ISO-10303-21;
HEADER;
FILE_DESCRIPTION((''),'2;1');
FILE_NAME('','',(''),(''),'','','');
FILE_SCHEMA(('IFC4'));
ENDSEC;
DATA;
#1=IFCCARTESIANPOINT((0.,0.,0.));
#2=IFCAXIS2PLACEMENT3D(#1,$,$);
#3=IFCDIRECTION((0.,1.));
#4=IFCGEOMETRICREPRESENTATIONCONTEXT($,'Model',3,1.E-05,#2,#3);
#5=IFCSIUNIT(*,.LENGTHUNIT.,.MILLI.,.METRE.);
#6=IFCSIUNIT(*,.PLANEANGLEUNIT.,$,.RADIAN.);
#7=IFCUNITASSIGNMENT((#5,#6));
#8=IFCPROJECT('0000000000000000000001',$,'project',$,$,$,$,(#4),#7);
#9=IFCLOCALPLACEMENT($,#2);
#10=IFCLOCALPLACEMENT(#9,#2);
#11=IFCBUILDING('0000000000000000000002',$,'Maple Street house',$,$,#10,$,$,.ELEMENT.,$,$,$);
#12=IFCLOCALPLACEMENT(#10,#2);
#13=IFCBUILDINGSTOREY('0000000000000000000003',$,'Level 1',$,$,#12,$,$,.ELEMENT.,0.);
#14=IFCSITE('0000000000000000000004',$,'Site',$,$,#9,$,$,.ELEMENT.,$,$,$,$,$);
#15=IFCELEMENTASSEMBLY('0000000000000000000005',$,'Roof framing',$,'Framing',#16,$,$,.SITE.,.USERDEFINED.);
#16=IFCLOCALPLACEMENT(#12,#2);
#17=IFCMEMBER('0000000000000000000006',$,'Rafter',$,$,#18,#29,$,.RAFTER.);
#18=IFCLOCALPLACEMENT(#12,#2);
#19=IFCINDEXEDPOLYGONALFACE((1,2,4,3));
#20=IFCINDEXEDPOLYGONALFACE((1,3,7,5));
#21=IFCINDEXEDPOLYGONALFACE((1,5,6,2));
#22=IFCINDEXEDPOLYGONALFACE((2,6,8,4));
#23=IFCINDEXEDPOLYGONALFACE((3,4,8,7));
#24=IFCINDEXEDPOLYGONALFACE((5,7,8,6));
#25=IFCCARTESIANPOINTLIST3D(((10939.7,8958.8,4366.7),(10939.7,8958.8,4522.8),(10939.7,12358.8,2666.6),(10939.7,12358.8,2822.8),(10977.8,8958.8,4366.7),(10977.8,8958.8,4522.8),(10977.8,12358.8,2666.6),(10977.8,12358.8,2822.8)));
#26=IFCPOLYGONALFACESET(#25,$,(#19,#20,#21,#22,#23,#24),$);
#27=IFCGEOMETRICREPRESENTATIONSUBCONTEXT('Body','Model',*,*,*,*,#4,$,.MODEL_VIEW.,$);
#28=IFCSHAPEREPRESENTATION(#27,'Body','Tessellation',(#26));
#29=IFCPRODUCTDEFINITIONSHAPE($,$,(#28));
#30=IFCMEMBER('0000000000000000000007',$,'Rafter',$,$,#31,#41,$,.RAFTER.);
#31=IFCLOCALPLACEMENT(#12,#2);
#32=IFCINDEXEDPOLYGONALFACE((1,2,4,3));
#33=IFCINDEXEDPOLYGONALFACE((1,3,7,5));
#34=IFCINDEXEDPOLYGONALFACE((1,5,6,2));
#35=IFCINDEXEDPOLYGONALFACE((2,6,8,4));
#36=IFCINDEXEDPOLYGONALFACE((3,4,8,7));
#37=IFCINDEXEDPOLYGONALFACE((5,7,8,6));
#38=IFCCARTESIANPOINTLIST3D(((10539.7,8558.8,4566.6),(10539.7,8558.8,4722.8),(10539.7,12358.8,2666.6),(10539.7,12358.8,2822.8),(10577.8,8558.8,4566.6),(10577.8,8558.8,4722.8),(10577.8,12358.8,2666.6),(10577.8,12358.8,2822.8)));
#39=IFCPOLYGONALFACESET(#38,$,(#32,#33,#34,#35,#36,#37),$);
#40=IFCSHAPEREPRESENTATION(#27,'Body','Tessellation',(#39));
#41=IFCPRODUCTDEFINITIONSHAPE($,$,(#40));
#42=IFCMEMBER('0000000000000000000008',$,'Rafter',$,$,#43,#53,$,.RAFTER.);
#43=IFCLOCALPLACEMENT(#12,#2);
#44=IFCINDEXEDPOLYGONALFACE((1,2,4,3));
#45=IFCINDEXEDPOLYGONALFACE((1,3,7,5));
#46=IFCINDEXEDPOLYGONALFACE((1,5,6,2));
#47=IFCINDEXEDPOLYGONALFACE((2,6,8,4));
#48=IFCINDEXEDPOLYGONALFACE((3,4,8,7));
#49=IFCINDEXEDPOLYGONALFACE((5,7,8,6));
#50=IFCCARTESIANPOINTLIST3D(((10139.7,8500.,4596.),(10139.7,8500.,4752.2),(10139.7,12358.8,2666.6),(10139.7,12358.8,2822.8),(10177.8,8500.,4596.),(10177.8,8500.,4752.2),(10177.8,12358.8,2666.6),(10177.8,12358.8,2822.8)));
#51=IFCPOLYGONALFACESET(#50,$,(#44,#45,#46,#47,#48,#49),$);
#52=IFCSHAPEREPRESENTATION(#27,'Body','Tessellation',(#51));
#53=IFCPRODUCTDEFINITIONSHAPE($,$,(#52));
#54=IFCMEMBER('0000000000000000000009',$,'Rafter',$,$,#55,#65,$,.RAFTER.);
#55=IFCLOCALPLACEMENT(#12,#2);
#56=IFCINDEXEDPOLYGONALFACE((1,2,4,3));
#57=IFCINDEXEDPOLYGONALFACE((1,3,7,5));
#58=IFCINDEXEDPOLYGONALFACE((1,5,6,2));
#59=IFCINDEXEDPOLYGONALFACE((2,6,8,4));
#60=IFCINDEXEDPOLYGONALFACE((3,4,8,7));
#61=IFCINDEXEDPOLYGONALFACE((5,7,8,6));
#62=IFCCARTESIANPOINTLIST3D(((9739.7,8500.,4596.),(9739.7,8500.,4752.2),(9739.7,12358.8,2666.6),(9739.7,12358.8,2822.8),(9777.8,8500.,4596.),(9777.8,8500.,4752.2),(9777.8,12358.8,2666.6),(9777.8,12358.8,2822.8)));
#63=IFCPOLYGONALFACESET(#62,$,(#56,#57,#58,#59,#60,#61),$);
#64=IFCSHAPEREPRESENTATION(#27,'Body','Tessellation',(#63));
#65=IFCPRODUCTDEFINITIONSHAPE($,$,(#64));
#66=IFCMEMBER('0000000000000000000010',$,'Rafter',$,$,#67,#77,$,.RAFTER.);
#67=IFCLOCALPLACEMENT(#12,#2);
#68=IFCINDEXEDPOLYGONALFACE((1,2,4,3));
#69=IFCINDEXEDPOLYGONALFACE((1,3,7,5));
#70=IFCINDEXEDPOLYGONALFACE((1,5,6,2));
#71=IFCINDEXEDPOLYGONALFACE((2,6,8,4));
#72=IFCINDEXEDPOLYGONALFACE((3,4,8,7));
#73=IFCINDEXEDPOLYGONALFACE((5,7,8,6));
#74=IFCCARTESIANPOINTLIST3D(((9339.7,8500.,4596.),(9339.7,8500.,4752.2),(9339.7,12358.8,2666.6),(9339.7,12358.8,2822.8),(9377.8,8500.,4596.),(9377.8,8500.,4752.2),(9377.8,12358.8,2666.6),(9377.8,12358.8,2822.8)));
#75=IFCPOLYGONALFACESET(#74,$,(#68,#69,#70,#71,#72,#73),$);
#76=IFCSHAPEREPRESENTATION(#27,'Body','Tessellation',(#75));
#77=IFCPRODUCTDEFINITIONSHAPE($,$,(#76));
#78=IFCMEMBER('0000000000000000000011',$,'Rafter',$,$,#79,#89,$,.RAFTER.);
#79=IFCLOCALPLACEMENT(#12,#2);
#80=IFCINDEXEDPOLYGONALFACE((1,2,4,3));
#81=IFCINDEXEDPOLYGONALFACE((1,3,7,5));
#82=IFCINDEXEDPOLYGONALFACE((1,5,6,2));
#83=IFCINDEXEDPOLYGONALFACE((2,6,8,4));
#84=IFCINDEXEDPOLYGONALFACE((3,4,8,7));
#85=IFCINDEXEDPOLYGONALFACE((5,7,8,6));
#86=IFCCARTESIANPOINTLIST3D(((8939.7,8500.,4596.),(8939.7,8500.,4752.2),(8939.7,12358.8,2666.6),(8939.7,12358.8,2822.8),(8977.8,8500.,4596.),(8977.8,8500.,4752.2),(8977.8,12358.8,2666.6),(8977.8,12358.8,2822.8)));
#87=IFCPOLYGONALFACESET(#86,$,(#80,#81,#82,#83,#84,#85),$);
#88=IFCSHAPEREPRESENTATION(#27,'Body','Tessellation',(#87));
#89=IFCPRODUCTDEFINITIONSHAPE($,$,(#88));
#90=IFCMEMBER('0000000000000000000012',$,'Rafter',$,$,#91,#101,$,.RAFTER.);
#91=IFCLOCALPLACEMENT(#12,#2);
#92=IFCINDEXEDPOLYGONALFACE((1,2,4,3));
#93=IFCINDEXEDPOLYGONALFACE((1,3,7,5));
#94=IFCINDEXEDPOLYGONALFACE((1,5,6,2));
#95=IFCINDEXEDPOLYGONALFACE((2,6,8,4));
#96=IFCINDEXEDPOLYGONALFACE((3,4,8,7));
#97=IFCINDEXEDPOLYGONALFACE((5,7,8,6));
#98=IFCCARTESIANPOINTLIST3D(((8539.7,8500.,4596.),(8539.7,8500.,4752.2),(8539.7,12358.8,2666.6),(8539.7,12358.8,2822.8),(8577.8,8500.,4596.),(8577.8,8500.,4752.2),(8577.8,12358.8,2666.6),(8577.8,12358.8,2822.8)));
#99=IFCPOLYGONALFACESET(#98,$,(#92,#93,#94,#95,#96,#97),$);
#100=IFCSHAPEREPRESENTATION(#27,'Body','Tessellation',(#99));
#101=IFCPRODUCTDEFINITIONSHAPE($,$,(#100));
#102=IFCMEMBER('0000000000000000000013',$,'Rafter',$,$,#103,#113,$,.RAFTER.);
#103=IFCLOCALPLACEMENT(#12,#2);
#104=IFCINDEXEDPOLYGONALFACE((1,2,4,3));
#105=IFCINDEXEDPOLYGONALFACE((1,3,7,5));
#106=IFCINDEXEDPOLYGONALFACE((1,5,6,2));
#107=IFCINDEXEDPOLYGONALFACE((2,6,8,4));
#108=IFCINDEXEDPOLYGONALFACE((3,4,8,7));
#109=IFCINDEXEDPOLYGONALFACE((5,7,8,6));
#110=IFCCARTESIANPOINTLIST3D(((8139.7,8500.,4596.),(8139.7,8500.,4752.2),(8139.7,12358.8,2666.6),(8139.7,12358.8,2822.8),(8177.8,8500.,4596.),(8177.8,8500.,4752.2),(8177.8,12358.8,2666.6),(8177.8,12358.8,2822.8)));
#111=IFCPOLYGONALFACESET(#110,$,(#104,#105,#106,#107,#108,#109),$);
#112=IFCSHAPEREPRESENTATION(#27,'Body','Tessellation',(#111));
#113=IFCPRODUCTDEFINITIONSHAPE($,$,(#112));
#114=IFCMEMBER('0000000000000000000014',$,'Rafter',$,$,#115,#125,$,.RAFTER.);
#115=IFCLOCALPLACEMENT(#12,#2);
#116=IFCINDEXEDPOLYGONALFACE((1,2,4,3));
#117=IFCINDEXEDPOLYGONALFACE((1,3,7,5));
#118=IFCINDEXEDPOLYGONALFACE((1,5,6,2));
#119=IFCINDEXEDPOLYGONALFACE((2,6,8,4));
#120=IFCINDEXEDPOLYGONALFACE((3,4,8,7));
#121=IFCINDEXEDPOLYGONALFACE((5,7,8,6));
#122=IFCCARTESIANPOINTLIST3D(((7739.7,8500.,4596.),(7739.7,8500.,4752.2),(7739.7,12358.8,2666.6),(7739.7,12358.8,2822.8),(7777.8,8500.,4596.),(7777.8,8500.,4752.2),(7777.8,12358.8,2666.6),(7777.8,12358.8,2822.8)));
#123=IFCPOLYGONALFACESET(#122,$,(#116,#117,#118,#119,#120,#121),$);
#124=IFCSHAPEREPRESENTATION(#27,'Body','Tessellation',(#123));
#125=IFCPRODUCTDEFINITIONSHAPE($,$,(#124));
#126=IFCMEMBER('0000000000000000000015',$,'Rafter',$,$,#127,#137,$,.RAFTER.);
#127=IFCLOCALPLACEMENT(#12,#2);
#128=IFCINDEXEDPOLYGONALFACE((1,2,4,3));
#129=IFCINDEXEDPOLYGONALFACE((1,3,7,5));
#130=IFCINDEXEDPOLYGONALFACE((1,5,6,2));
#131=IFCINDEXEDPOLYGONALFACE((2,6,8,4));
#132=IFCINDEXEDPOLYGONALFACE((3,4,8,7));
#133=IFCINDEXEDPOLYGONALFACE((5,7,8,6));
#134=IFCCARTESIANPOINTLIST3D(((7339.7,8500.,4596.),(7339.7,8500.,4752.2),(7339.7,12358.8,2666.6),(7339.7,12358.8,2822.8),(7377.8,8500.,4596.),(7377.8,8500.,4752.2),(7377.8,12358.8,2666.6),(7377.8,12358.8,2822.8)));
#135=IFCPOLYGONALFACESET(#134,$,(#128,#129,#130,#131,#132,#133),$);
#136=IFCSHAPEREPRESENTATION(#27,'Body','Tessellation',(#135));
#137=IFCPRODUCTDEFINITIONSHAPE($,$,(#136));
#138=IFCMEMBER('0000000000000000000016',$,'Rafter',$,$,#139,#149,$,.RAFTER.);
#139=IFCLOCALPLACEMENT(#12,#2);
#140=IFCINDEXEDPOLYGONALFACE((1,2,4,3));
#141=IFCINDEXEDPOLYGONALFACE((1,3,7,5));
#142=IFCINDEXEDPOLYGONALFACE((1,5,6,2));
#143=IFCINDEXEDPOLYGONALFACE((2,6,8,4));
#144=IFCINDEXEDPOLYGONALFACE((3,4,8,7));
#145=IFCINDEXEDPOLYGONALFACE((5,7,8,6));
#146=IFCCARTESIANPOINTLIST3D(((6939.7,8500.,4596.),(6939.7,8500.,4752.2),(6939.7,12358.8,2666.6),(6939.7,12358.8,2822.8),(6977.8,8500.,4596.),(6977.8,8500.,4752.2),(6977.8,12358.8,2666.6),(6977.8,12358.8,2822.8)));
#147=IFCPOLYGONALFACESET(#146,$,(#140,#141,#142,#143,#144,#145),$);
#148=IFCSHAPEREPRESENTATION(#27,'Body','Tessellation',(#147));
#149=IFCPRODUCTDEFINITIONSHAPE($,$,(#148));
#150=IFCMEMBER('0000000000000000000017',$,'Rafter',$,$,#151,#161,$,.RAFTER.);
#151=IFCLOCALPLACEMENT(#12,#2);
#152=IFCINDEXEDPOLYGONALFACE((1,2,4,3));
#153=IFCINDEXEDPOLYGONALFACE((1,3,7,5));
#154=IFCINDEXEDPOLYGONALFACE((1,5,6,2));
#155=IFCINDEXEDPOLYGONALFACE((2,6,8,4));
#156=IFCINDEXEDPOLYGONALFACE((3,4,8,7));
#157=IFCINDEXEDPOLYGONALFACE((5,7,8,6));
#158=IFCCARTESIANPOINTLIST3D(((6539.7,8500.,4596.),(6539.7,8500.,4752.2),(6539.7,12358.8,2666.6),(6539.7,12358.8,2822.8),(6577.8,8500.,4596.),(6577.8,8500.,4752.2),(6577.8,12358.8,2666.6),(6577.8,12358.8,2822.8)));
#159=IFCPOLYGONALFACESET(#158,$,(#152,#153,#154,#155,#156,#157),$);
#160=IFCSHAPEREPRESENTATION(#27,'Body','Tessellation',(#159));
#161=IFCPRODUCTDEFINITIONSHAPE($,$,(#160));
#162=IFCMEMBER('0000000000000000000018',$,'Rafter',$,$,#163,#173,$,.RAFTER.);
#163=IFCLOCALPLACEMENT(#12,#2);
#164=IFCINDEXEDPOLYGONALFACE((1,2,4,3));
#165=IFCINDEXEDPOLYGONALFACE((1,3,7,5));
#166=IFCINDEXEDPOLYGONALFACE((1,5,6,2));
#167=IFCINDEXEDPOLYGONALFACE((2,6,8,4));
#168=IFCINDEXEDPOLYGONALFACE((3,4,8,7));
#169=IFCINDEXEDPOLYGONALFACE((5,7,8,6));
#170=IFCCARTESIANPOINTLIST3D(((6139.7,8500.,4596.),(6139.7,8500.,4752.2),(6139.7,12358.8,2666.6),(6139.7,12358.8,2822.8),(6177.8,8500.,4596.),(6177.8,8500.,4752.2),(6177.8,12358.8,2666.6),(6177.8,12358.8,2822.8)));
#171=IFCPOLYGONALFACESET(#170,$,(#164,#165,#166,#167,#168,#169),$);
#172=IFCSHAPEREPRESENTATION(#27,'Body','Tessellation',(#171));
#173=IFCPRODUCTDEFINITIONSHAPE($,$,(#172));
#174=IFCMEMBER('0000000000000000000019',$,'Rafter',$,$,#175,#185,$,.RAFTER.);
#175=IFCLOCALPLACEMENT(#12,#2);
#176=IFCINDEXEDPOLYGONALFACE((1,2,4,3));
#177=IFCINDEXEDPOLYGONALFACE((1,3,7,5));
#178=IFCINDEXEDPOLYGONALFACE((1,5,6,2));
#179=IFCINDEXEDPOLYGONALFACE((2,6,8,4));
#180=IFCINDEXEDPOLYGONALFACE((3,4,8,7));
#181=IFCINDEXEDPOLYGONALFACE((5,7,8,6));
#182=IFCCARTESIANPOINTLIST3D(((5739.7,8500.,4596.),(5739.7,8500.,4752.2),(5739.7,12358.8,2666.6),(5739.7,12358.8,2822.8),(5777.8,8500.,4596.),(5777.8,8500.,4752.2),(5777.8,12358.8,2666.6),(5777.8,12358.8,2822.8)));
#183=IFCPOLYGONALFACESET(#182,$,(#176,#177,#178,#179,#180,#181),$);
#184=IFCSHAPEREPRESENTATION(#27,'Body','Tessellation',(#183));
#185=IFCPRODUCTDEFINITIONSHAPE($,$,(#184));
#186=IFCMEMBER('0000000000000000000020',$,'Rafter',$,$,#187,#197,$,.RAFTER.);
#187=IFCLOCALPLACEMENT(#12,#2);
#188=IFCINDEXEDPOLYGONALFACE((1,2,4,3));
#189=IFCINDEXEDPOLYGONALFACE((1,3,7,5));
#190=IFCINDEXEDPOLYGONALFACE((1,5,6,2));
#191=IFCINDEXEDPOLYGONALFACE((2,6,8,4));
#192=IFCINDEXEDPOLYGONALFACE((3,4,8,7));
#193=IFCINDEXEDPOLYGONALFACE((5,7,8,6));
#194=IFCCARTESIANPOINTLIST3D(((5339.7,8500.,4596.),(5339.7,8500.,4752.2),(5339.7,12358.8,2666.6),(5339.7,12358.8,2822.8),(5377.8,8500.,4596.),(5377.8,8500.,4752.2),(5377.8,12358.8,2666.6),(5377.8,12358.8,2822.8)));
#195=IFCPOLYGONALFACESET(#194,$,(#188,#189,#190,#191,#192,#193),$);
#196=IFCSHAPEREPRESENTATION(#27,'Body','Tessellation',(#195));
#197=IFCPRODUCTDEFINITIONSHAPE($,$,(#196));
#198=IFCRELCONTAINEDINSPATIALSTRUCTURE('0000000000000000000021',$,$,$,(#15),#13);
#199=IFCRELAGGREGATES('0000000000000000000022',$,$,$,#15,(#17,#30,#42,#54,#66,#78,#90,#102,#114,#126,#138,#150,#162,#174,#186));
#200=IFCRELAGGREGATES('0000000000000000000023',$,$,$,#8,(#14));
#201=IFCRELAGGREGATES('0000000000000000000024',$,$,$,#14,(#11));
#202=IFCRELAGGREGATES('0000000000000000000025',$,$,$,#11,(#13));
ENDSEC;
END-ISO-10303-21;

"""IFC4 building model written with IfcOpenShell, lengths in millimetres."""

from ifc_helpers import new_model, si_unit, direction, frame, origin, origin_with_axes, place, context, subcontext, project, spatial, polyline, outline, extrude, element, aggregate, save


model = new_model("IFC4")

# Units and contexts
model_context = context("Model", 3, precision=1e-05, world=origin(), true_north=direction((0.0, 1.0)))
body_context = subcontext(model_context, "Body", "Model", "MODEL_VIEW")
ifc_project = project(units=[si_unit("LENGTHUNIT", "METRE", prefix="MILLI"), si_unit("PLANEANGLEUNIT", "RADIAN")], contexts=[model_context])

# Site, building, storey
site_placement = place(None, origin())
site = spatial("IfcSite", under=ifc_project, at=site_placement, Name="Site", CompositionType="ELEMENT")
building_placement = place(site_placement, origin())
building = spatial("IfcBuilding", under=site, at=building_placement, Name="Maple Street house", CompositionType="ELEMENT")
storey_placement = place(building_placement, origin())
storey = spatial("IfcBuildingStorey", under=building, at=storey_placement, Name="Level 1", CompositionType="ELEMENT", Elevation=0.0)

# Element assembly, members
assembly_placement = place(storey_placement, origin_with_axes())
assembly = element("IfcElementAssembly", 1, at=assembly_placement, inside=storey, Name="Roof framing", ObjectType="Framing", AssemblyPlace="SITE", PredefinedType="USERDEFINED")
member_1_placement = place(storey_placement, origin_with_axes())
member_1 = element("IfcMember", 2, at=member_1_placement, Name="Rafter", PredefinedType="RAFTER", context=body_context, shape_type="SweptSolid", body=[
    extrude(outline(polyline([(0.0, 0.0), (38.1, 0.0), (38.1, 156.2), (0.0, 156.2), (0.0, 0.0)])), frame((10939.7, 12358.8, 2666.7), z_axis=(0.0, -1.0, 0.0), x_axis=(1.0, 0.0, 0.0)), (0.0, 0.447214, 0.894427), 3801.3),
])
member_2_placement = place(storey_placement, origin_with_axes())
member_2 = element("IfcMember", 3, at=member_2_placement, Name="Rafter", PredefinedType="RAFTER", context=body_context, shape_type="SweptSolid", body=[
    extrude(outline(polyline([(0.0, 0.0), (38.1, 0.0), (38.1, 156.2), (0.0, 156.2), (0.0, 0.0)])), frame((10539.7, 12358.8, 2666.7), z_axis=(0.0, -1.0, 0.0), x_axis=(1.0, 0.0, 0.0)), (0.0, 0.447214, 0.894427), 4248.5),
])
member_3_placement = place(storey_placement, origin_with_axes())
member_3 = element("IfcMember", 4, at=member_3_placement, Name="Rafter", PredefinedType="RAFTER", context=body_context, shape_type="SweptSolid", body=[
    extrude(outline(polyline([(0.0, 0.0), (38.1, 0.0), (38.1, 156.2), (0.0, 156.2), (0.0, 0.0)])), frame((10139.7, 12358.8, 2666.7), z_axis=(0.0, -1.0, 0.0), x_axis=(1.0, 0.0, 0.0)), (0.0, 0.447214, 0.894427), 4314.2),
])
member_4_placement = place(storey_placement, origin_with_axes())
member_4 = element("IfcMember", 5, at=member_4_placement, Name="Rafter", PredefinedType="RAFTER", context=body_context, shape_type="SweptSolid", body=[
    extrude(outline(polyline([(0.0, 0.0), (38.1, 0.0), (38.1, 156.2), (0.0, 156.2), (0.0, 0.0)])), frame((9739.7, 12358.8, 2666.7), z_axis=(0.0, -1.0, 0.0), x_axis=(1.0, 0.0, 0.0)), (0.0, 0.447214, 0.894427), 4314.2),
])
member_5_placement = place(storey_placement, origin_with_axes())
member_5 = element("IfcMember", 6, at=member_5_placement, Name="Rafter", PredefinedType="RAFTER", context=body_context, shape_type="SweptSolid", body=[
    extrude(outline(polyline([(0.0, 0.0), (38.1, 0.0), (38.1, 156.2), (0.0, 156.2), (0.0, 0.0)])), frame((9339.7, 12358.8, 2666.7), z_axis=(0.0, -1.0, 0.0), x_axis=(1.0, 0.0, 0.0)), (0.0, 0.447214, 0.894427), 4314.2),
])
member_6_placement = place(storey_placement, origin_with_axes())
member_6 = element("IfcMember", 7, at=member_6_placement, Name="Rafter", PredefinedType="RAFTER", context=body_context, shape_type="SweptSolid", body=[
    extrude(outline(polyline([(0.0, 0.0), (38.1, 0.0), (38.1, 156.2), (0.0, 156.2), (0.0, 0.0)])), frame((8939.7, 12358.8, 2666.7), z_axis=(0.0, -1.0, 0.0), x_axis=(1.0, 0.0, 0.0)), (0.0, 0.447214, 0.894427), 4314.2),
])
member_7_placement = place(storey_placement, origin_with_axes())
member_7 = element("IfcMember", 8, at=member_7_placement, Name="Rafter", PredefinedType="RAFTER", context=body_context, shape_type="SweptSolid", body=[
    extrude(outline(polyline([(0.0, 0.0), (38.1, 0.0), (38.1, 156.2), (0.0, 156.2), (0.0, 0.0)])), frame((8539.7, 12358.8, 2666.7), z_axis=(0.0, -1.0, 0.0), x_axis=(1.0, 0.0, 0.0)), (0.0, 0.447214, 0.894427), 4314.2),
])
member_8_placement = place(storey_placement, origin_with_axes())
member_8 = element("IfcMember", 9, at=member_8_placement, Name="Rafter", PredefinedType="RAFTER", context=body_context, shape_type="SweptSolid", body=[
    extrude(outline(polyline([(0.0, 0.0), (38.1, 0.0), (38.1, 156.2), (0.0, 156.2), (0.0, 0.0)])), frame((8139.7, 12358.8, 2666.7), z_axis=(0.0, -1.0, 0.0), x_axis=(1.0, 0.0, 0.0)), (0.0, 0.447214, 0.894427), 4314.2),
])
member_9_placement = place(storey_placement, origin_with_axes())
member_9 = element("IfcMember", 10, at=member_9_placement, Name="Rafter", PredefinedType="RAFTER", context=body_context, shape_type="SweptSolid", body=[
    extrude(outline(polyline([(0.0, 0.0), (38.1, 0.0), (38.1, 156.2), (0.0, 156.2), (0.0, 0.0)])), frame((7739.7, 12358.8, 2666.7), z_axis=(0.0, -1.0, 0.0), x_axis=(1.0, 0.0, 0.0)), (0.0, 0.447214, 0.894427), 4314.2),
])
member_10_placement = place(storey_placement, origin_with_axes())
member_10 = element("IfcMember", 11, at=member_10_placement, Name="Rafter", PredefinedType="RAFTER", context=body_context, shape_type="SweptSolid", body=[
    extrude(outline(polyline([(0.0, 0.0), (38.1, 0.0), (38.1, 156.2), (0.0, 156.2), (0.0, 0.0)])), frame((7339.7, 12358.8, 2666.7), z_axis=(0.0, -1.0, 0.0), x_axis=(1.0, 0.0, 0.0)), (0.0, 0.447214, 0.894427), 4314.2),
])
member_11_placement = place(storey_placement, origin_with_axes())
member_11 = element("IfcMember", 12, at=member_11_placement, Name="Rafter", PredefinedType="RAFTER", context=body_context, shape_type="SweptSolid", body=[
    extrude(outline(polyline([(0.0, 0.0), (38.1, 0.0), (38.1, 156.2), (0.0, 156.2), (0.0, 0.0)])), frame((6939.7, 12358.8, 2666.7), z_axis=(0.0, -1.0, 0.0), x_axis=(1.0, 0.0, 0.0)), (0.0, 0.447214, 0.894427), 4314.2),
])
member_12_placement = place(storey_placement, origin_with_axes())
member_12 = element("IfcMember", 13, at=member_12_placement, Name="Rafter", PredefinedType="RAFTER", context=body_context, shape_type="SweptSolid", body=[
    extrude(outline(polyline([(0.0, 0.0), (38.1, 0.0), (38.1, 156.2), (0.0, 156.2), (0.0, 0.0)])), frame((6539.7, 12358.8, 2666.7), z_axis=(0.0, -1.0, 0.0), x_axis=(1.0, 0.0, 0.0)), (0.0, 0.447214, 0.894427), 4314.2),
])
member_13_placement = place(storey_placement, origin_with_axes())
member_13 = element("IfcMember", 14, at=member_13_placement, Name="Rafter", PredefinedType="RAFTER", context=body_context, shape_type="SweptSolid", body=[
    extrude(outline(polyline([(0.0, 0.0), (38.1, 0.0), (38.1, 156.2), (0.0, 156.2), (0.0, 0.0)])), frame((6139.7, 12358.8, 2666.7), z_axis=(0.0, -1.0, 0.0), x_axis=(1.0, 0.0, 0.0)), (0.0, 0.447214, 0.894427), 4314.2),
])
member_14_placement = place(storey_placement, origin_with_axes())
member_14 = element("IfcMember", 15, at=member_14_placement, Name="Rafter", PredefinedType="RAFTER", context=body_context, shape_type="SweptSolid", body=[
    extrude(outline(polyline([(0.0, 0.0), (38.1, 0.0), (38.1, 156.2), (0.0, 156.2), (0.0, 0.0)])), frame((5739.7, 12358.8, 2666.7), z_axis=(0.0, -1.0, 0.0), x_axis=(1.0, 0.0, 0.0)), (0.0, 0.447214, 0.894427), 4314.2),
])
member_15_placement = place(storey_placement, origin_with_axes())
member_15 = element("IfcMember", 16, at=member_15_placement, Name="Rafter", PredefinedType="RAFTER", context=body_context, shape_type="SweptSolid", body=[
    extrude(outline(polyline([(0.0, 0.0), (38.1, 0.0), (38.1, 156.2), (0.0, 156.2), (0.0, 0.0)])), frame((5339.7, 12358.8, 2666.7), z_axis=(0.0, -1.0, 0.0), x_axis=(1.0, 0.0, 0.0)), (0.0, 0.447214, 0.894427), 4314.2),
])
aggregate(assembly, [member_1, member_2, member_3, member_4, member_5, member_6, member_7, member_8, member_9, member_10, member_11, member_12, member_13, member_14, member_15])

save(model, "model.ifc")
